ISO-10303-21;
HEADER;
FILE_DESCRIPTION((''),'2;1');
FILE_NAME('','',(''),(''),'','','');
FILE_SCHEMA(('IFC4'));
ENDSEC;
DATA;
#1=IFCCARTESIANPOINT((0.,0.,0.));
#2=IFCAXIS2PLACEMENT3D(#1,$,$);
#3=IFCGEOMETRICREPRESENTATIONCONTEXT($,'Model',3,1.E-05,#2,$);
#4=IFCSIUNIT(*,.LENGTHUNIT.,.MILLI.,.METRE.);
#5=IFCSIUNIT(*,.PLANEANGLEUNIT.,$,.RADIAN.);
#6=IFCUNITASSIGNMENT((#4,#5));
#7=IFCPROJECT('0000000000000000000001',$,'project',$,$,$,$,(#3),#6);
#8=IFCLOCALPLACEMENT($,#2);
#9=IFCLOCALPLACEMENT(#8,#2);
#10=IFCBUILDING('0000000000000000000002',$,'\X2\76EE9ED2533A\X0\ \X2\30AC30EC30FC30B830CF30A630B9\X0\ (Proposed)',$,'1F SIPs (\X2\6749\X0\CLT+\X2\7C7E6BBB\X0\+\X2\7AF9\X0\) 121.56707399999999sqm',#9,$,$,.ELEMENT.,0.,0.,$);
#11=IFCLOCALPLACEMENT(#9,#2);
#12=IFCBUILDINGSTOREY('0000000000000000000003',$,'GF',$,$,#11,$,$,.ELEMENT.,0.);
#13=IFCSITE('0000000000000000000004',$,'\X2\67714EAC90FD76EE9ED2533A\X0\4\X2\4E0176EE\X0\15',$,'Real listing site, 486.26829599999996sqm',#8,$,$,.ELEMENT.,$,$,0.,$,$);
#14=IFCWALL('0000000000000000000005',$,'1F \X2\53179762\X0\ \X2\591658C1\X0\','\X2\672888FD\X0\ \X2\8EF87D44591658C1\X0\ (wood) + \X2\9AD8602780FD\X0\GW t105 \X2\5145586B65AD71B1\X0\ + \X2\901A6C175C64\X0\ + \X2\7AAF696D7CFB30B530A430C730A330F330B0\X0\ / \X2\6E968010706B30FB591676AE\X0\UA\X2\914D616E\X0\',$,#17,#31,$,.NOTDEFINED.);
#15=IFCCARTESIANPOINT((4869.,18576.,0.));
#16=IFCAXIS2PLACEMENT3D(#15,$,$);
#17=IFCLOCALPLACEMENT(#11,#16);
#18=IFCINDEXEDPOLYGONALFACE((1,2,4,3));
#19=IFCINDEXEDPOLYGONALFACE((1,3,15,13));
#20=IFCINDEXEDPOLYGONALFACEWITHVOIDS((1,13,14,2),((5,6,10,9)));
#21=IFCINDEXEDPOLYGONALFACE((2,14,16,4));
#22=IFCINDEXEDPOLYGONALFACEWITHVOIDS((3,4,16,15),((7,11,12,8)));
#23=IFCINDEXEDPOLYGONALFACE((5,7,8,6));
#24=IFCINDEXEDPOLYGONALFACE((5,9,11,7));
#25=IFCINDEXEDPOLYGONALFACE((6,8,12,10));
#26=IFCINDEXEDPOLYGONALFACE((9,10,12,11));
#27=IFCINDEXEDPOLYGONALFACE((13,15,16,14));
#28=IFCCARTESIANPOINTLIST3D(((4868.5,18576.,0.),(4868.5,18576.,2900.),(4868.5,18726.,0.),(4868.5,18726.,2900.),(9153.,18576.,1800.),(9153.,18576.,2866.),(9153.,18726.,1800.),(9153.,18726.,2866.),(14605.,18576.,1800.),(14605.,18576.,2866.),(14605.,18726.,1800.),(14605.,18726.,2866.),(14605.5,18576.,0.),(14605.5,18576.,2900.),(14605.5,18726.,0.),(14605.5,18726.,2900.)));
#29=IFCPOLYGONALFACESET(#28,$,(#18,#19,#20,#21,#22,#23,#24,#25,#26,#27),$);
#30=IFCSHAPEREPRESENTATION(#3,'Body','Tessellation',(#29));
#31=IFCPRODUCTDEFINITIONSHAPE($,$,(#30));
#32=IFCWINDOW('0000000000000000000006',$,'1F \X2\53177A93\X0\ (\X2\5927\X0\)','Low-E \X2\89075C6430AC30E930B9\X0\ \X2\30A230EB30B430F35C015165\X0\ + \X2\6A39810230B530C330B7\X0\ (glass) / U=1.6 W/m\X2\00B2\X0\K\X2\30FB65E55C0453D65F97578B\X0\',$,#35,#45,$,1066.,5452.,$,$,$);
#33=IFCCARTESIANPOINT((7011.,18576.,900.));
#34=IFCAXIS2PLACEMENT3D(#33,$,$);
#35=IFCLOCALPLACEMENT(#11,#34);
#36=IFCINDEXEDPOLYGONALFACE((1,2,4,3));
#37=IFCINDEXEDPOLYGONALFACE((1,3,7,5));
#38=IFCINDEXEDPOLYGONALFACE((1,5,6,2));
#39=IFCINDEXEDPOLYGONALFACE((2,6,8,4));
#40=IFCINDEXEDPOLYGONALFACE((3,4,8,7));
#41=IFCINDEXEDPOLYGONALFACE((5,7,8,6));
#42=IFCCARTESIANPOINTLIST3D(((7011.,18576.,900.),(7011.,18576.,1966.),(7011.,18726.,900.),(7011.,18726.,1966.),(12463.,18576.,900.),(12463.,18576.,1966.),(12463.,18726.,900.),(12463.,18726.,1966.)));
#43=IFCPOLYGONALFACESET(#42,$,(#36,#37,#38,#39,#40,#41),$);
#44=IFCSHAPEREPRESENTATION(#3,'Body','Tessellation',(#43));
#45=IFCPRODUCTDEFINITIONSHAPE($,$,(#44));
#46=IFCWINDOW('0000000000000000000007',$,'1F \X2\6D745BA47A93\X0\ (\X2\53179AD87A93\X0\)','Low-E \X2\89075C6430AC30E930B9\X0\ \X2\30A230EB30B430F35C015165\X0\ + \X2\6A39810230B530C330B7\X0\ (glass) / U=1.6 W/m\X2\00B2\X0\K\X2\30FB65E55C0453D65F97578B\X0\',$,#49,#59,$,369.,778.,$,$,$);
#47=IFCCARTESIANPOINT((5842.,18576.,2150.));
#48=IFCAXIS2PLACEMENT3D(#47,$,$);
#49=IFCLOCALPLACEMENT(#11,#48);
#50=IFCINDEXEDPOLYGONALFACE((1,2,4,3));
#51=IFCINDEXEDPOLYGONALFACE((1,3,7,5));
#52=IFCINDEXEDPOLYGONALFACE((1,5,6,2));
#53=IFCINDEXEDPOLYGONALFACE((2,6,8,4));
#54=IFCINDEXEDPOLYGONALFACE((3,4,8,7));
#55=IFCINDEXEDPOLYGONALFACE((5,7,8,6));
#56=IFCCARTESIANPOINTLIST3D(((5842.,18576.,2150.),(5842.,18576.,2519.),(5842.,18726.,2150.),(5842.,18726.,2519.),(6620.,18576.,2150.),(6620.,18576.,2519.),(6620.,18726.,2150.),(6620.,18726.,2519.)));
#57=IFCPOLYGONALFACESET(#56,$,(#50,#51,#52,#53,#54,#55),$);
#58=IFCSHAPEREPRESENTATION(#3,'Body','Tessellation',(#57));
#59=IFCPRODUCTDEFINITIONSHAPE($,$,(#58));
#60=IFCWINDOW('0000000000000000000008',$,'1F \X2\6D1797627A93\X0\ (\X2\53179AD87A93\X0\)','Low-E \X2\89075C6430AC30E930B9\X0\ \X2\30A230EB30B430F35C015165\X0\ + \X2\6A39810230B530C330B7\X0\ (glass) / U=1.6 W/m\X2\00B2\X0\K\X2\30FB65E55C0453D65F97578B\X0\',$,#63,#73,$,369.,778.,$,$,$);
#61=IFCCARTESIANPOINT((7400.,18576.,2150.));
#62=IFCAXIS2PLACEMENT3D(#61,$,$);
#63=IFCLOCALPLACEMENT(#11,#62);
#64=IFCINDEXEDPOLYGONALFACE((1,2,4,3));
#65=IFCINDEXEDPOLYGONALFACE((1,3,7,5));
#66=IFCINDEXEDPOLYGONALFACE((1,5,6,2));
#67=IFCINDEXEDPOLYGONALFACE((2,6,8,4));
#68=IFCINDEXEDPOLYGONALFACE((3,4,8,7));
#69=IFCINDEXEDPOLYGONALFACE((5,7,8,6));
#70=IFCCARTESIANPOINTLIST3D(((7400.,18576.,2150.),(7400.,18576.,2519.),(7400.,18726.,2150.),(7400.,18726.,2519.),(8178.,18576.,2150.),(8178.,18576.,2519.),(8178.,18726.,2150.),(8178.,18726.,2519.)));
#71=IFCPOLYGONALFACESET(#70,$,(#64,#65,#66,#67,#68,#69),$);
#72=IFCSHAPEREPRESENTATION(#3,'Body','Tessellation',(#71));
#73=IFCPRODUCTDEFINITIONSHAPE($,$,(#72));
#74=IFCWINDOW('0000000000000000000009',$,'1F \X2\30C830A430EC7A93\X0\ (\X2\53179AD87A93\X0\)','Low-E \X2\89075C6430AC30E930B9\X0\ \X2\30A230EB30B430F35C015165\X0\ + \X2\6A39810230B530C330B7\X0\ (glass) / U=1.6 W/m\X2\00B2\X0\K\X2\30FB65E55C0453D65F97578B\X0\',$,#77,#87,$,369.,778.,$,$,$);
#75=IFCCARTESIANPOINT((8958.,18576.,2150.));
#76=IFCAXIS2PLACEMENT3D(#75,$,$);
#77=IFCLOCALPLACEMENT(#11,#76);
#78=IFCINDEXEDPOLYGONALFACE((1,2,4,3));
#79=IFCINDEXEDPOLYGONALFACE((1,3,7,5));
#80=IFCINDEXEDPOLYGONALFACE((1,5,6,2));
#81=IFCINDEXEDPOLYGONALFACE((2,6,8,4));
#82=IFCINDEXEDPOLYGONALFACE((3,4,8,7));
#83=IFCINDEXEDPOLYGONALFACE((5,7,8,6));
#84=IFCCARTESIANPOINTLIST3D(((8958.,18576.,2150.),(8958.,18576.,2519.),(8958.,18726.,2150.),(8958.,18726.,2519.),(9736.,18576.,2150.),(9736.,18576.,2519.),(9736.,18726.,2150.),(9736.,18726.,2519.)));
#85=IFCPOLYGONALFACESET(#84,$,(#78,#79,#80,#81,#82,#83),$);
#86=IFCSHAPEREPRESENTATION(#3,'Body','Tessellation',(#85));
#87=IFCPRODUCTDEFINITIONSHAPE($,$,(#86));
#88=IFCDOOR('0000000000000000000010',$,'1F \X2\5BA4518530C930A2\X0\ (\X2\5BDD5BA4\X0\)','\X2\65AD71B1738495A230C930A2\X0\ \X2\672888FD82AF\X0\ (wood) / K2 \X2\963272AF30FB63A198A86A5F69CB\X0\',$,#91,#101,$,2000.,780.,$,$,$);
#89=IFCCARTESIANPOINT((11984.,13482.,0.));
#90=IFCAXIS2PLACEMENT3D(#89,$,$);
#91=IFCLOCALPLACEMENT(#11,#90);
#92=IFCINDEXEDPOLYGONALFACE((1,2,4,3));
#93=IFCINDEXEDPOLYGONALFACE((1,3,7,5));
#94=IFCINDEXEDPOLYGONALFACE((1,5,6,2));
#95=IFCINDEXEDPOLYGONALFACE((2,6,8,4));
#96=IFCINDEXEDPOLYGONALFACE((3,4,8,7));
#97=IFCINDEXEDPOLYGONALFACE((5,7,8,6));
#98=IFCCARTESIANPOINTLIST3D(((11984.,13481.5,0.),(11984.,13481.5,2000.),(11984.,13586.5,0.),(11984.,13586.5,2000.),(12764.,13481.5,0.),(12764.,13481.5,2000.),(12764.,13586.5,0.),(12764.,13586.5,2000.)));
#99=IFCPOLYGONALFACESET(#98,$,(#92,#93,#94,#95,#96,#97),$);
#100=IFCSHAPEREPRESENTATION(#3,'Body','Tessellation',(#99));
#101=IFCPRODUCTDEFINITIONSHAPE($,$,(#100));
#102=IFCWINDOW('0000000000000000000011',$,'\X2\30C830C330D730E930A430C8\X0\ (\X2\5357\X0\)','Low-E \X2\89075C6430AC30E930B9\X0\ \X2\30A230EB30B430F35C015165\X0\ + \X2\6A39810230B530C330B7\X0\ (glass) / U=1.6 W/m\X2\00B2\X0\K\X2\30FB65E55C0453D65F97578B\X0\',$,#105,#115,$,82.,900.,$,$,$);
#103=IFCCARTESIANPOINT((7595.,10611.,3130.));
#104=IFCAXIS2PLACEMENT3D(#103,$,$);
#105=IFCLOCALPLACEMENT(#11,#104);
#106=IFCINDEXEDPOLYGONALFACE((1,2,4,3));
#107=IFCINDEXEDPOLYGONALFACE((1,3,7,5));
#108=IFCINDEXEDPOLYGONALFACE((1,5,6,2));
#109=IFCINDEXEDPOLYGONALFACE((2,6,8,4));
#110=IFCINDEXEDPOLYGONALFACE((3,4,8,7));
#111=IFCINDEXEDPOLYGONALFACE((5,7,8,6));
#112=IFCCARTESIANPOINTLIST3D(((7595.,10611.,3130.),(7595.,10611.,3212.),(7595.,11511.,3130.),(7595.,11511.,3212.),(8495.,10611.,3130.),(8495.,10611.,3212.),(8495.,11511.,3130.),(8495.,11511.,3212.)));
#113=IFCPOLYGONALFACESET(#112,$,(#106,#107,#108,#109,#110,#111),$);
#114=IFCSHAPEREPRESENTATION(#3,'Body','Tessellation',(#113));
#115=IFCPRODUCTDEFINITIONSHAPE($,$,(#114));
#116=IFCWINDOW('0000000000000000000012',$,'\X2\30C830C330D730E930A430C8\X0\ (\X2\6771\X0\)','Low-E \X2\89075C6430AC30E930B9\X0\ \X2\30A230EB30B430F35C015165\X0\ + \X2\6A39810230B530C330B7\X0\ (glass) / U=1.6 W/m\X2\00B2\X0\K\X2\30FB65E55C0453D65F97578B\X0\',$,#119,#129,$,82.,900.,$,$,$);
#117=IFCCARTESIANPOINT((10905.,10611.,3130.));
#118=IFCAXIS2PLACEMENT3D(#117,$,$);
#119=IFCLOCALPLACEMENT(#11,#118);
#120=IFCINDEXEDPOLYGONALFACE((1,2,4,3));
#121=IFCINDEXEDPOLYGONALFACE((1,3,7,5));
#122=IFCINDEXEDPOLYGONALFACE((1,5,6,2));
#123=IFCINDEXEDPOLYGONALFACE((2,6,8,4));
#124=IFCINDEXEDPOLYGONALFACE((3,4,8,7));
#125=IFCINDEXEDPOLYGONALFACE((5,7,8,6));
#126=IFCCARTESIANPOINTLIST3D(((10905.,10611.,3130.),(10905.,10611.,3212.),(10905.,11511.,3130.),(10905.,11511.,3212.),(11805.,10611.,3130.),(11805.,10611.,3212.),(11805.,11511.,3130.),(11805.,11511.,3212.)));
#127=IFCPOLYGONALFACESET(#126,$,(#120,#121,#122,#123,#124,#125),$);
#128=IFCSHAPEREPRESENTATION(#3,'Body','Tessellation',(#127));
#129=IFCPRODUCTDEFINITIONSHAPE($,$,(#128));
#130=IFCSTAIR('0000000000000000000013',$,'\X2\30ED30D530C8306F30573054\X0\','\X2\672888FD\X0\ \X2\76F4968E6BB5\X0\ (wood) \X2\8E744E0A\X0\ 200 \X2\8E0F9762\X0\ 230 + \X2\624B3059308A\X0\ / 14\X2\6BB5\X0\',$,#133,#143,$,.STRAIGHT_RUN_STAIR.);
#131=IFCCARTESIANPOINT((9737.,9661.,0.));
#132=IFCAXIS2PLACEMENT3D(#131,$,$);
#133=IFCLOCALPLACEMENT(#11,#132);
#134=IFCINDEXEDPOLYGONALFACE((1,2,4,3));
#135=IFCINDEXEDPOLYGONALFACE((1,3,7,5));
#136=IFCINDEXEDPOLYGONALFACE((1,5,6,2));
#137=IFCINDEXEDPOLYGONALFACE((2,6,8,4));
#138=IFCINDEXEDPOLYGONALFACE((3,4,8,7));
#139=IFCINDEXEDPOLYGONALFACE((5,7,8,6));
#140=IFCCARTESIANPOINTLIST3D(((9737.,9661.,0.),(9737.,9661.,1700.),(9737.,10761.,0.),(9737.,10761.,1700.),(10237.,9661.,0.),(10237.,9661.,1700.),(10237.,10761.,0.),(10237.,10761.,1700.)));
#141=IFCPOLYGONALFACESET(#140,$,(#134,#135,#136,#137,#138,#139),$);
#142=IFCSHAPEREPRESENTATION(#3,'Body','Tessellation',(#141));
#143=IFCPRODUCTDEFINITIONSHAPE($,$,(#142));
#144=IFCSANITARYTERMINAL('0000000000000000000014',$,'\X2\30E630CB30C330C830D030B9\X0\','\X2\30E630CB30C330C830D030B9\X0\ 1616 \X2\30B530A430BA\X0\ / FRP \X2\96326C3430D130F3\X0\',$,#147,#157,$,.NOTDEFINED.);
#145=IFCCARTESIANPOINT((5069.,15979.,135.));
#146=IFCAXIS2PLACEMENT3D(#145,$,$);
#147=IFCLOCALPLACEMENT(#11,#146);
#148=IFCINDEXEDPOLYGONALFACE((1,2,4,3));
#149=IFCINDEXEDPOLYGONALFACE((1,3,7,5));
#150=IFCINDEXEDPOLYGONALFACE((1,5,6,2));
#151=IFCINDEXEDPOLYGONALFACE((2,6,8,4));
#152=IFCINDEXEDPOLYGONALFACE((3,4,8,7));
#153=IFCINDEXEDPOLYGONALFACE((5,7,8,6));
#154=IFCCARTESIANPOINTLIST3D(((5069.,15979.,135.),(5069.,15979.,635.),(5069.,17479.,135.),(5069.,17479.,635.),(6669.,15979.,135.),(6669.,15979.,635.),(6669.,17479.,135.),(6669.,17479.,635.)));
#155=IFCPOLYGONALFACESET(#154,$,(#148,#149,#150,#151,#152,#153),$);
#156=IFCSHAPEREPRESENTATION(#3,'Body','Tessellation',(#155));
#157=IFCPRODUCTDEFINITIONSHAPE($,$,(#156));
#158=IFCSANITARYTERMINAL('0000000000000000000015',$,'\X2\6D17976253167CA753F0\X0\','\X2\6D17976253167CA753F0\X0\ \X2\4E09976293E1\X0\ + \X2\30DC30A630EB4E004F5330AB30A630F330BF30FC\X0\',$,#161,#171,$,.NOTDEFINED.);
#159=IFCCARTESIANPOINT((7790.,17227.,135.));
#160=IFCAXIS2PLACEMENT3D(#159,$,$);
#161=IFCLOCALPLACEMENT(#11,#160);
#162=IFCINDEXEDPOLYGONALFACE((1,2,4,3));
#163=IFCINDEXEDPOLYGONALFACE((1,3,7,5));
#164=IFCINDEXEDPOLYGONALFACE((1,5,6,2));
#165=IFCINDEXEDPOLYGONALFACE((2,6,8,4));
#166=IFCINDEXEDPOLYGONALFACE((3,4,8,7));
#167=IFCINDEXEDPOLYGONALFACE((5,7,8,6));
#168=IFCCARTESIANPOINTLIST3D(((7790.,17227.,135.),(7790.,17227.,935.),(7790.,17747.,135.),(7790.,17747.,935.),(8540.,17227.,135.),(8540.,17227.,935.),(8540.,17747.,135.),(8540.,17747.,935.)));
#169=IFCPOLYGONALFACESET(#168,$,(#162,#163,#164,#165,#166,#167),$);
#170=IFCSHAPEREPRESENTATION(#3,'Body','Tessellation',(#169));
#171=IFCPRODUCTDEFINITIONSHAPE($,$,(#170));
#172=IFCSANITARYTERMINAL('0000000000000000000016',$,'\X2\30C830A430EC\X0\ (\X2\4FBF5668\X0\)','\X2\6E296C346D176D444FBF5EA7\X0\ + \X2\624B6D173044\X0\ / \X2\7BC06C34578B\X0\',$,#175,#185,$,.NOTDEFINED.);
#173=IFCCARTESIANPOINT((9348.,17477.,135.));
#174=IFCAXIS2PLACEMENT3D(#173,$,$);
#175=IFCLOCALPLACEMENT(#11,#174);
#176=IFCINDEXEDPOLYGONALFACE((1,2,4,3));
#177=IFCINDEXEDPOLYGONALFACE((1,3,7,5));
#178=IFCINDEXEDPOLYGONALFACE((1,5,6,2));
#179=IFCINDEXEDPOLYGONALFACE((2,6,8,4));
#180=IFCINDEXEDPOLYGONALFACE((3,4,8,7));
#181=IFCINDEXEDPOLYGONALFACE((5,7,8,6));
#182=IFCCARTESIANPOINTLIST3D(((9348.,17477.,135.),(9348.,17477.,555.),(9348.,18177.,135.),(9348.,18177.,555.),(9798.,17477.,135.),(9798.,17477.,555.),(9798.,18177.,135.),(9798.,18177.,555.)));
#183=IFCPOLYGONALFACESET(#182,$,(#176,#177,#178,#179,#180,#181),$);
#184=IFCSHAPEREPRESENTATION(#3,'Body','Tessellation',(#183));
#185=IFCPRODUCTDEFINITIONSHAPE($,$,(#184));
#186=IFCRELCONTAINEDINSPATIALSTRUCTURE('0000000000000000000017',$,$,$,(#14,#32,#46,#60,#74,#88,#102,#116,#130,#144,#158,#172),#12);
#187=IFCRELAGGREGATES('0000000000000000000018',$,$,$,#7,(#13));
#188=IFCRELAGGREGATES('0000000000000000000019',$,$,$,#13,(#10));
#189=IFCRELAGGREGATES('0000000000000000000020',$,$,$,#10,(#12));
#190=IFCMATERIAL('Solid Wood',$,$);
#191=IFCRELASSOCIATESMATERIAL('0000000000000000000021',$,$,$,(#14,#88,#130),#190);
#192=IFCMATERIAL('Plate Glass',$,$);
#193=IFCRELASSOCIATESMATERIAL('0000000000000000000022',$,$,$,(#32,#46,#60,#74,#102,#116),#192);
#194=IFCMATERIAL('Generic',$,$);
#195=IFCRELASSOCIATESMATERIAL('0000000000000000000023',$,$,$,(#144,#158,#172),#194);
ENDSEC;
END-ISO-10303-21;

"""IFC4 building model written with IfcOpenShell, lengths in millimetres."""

from ifc_helpers import new_model, si_unit, frame, frame_2d, origin, place, context, project, spatial, rectangle, extrude, material, element, fill, save


model = new_model("IFC4")

# Units and contexts
model_context = context("Model", 3, precision=1e-05, world=origin())
ifc_project = project(units=[si_unit("LENGTHUNIT", "METRE", prefix="MILLI"), si_unit("PLANEANGLEUNIT", "RADIAN")], contexts=[model_context])

# Site, building, storey
site_placement = place(None, origin())
site = spatial("IfcSite", under=ifc_project, at=site_placement, Name="東京都目黒区4丁目15", ObjectType="Real listing site, 486.26829599999996sqm", CompositionType="ELEMENT", RefElevation=0.0)
building_placement = place(site_placement, origin())
building = spatial("IfcBuilding", under=site, at=building_placement, Name="目黒区 ガレージハウス (Proposed)", ObjectType="1F SIPs (杉CLT+籾殻+竹) 121.56707399999999sqm", CompositionType="ELEMENT", ElevationOfRefHeight=0.0, ElevationOfTerrain=0.0)
storey_placement = place(building_placement, origin())
storey = spatial("IfcBuildingStorey", under=building, at=storey_placement, Name="GF", CompositionType="ELEMENT", Elevation=0.0)

# Shared definitions
ifc_material_1 = material(Name="Solid Wood")

# Wall, openings, windows
wall_1_placement = place(storey_placement, frame((4869.0, 18576.0, 0.0)))
wall_1 = element("IfcWall", 1, at=wall_1_placement, inside=storey, material=ifc_material_1, Name="1F 北面 外壁", Description="木製 軸組外壁 (wood) + 高性能GW t105 充填断熱 + 通気層 + 窯業系サイディング / 準耐火・外皮UA配慮", PredefinedType="NOTDEFINED", context=model_context, shape_type="SweptSolid", body=[
    extrude(rectangle(XDim=9737.0, YDim=150.0, at=frame_2d((4868.0, 75.0))), frame((4869.0, 18576.0, 0.0)), (0.0, 0.0, 1.0), 2900.0),
])
opening_1_placement = place(storey_placement, frame((7011.0, 18576.0, 900.0)))
opening_1 = element("IfcOpeningElement", 2, at=opening_1_placement, cuts=wall_1, PredefinedType="NOTDEFINED", context=model_context, shape_type="SweptSolid", body=[
    extrude(rectangle(XDim=5452.0, YDim=150.0, at=frame_2d((2726.0, 75.0))), frame((7011.0, 18576.0, 900.0)), (0.0, 0.0, 1.0), 1066.0),
])
opening_2_placement = place(storey_placement, frame((5842.0, 18576.0, 2150.0)))
opening_2 = element("IfcOpeningElement", 3, at=opening_2_placement, cuts=wall_1, PredefinedType="NOTDEFINED", context=model_context, shape_type="SweptSolid", body=[
    extrude(rectangle(XDim=778.0, YDim=150.0, at=frame_2d((389.0, 75.0))), frame((5842.0, 18576.0, 2150.0)), (0.0, 0.0, 1.0), 369.0),
])
opening_3_placement = place(storey_placement, frame((7400.0, 18576.0, 2150.0)))
opening_3 = element("IfcOpeningElement", 4, at=opening_3_placement, cuts=wall_1, PredefinedType="NOTDEFINED", context=model_context, shape_type="SweptSolid", body=[
    extrude(rectangle(XDim=778.0, YDim=150.0, at=frame_2d((389.0, 75.0))), frame((7400.0, 18576.0, 2150.0)), (0.0, 0.0, 1.0), 369.0),
])
opening_4_placement = place(storey_placement, frame((8958.0, 18576.0, 2150.0)))
opening_4 = element("IfcOpeningElement", 5, at=opening_4_placement, cuts=wall_1, PredefinedType="NOTDEFINED", context=model_context, shape_type="SweptSolid", body=[
    extrude(rectangle(XDim=778.0, YDim=150.0, at=frame_2d((389.0, 75.0))), frame((8958.0, 18576.0, 2150.0)), (0.0, 0.0, 1.0), 369.0),
])
ifc_material_2 = material(Name="Plate Glass")
window_1_placement = place(storey_placement, frame((7011.0, 18576.0, 900.0)))
window_1 = element("IfcWindow", 6, at=window_1_placement, inside=storey, material=ifc_material_2, Name="1F 北窓 (大)", Description="Low-E 複層ガラス アルゴン封入 + 樹脂サッシ (glass) / U=1.6 W/m²K・日射取得型", OverallHeight=1066.0, OverallWidth=5452.0, context=model_context, shape_type="SweptSolid", body=[
    extrude(rectangle(XDim=5452.0, YDim=150.0, at=frame_2d((2726.0, 75.0))), frame((7011.0, 18576.0, 900.0)), (0.0, 0.0, 1.0), 1066.0),
])
fill(opening_1, window_1)
window_2_placement = place(storey_placement, frame((5842.0, 18576.0, 2150.0)))
window_2 = element("IfcWindow", 7, at=window_2_placement, inside=storey, material=ifc_material_2, Name="1F 浴室窓 (北高窓)", Description="Low-E 複層ガラス アルゴン封入 + 樹脂サッシ (glass) / U=1.6 W/m²K・日射取得型", OverallHeight=369.0, OverallWidth=778.0, context=model_context, shape_type="SweptSolid", body=[
    extrude(rectangle(XDim=778.0, YDim=150.0, at=frame_2d((389.0, 75.0))), frame((5842.0, 18576.0, 2150.0)), (0.0, 0.0, 1.0), 369.0),
])
fill(opening_2, window_2)
window_3_placement = place(storey_placement, frame((7400.0, 18576.0, 2150.0)))
window_3 = element("IfcWindow", 8, at=window_3_placement, inside=storey, material=ifc_material_2, Name="1F 洗面窓 (北高窓)", Description="Low-E 複層ガラス アルゴン封入 + 樹脂サッシ (glass) / U=1.6 W/m²K・日射取得型", OverallHeight=369.0, OverallWidth=778.0, context=model_context, shape_type="SweptSolid", body=[
    extrude(rectangle(XDim=778.0, YDim=150.0, at=frame_2d((389.0, 75.0))), frame((7400.0, 18576.0, 2150.0)), (0.0, 0.0, 1.0), 369.0),
])
fill(opening_3, window_3)
window_4_placement = place(storey_placement, frame((8958.0, 18576.0, 2150.0)))
window_4 = element("IfcWindow", 9, at=window_4_placement, inside=storey, material=ifc_material_2, Name="1F トイレ窓 (北高窓)", Description="Low-E 複層ガラス アルゴン封入 + 樹脂サッシ (glass) / U=1.6 W/m²K・日射取得型", OverallHeight=369.0, OverallWidth=778.0, context=model_context, shape_type="SweptSolid", body=[
    extrude(rectangle(XDim=778.0, YDim=150.0, at=frame_2d((389.0, 75.0))), frame((8958.0, 18576.0, 2150.0)), (0.0, 0.0, 1.0), 369.0),
])
fill(opening_4, window_4)

# Door
door_1_placement = place(storey_placement, frame((11984.0, 13482.0, 0.0)))
element("IfcDoor", 10, at=door_1_placement, inside=storey, material=ifc_material_1, Name="1F 室内ドア (寝室)", Description="断熱玄関ドア 木製芯 (wood) / K2 防犯・採風機構", OverallHeight=2000.0, OverallWidth=780.0, context=model_context, shape_type="SweptSolid", body=[
    extrude(rectangle(XDim=780.0, YDim=105.0, at=frame_2d((390.0, 52.0))), frame((11984.0, 13482.0, 0.0)), (0.0, 0.0, 1.0), 2000.0),
])

# Windows
window_5_placement = place(storey_placement, frame((7595.0, 10611.0, 3130.0)))
element("IfcWindow", 11, at=window_5_placement, inside=storey, material=ifc_material_2, Name="トップライト (南)", Description="Low-E 複層ガラス アルゴン封入 + 樹脂サッシ (glass) / U=1.6 W/m²K・日射取得型", OverallHeight=82.0, OverallWidth=900.0, context=model_context, shape_type="SweptSolid", body=[
    extrude(rectangle(XDim=900.0, YDim=900.0, at=frame_2d((450.0, 450.0))), frame((7595.0, 10611.0, 3130.0)), (0.0, 0.0, 1.0), 82.0),
])
window_6_placement = place(storey_placement, frame((10905.0, 10611.0, 3130.0)))
element("IfcWindow", 12, at=window_6_placement, inside=storey, material=ifc_material_2, Name="トップライト (東)", Description="Low-E 複層ガラス アルゴン封入 + 樹脂サッシ (glass) / U=1.6 W/m²K・日射取得型", OverallHeight=82.0, OverallWidth=900.0, context=model_context, shape_type="SweptSolid", body=[
    extrude(rectangle(XDim=900.0, YDim=900.0, at=frame_2d((450.0, 450.0))), frame((10905.0, 10611.0, 3130.0)), (0.0, 0.0, 1.0), 82.0),
])

# Stair
stair_placement = place(storey_placement, frame((9737.0, 9661.0, 0.0)))
element("IfcStair", 13, at=stair_placement, inside=storey, material=ifc_material_1, Name="ロフトはしご", Description="木製 直階段 (wood) 蹴上 200 踏面 230 + 手すり / 14段", PredefinedType="STRAIGHT_RUN_STAIR", context=model_context, shape_type="SweptSolid", body=[
    extrude(rectangle(XDim=500.0, YDim=1100.0, at=frame_2d((250.0, 550.0))), frame((9737.0, 9661.0, 0.0)), (0.0, 0.0, 1.0), 1700.0),
])

# Sanitary terminals
ifc_material_3 = material(Name="Generic")
sanitary_terminal_1_placement = place(storey_placement, frame((5069.0, 15979.0, 135.0)))
element("IfcSanitaryTerminal", 14, at=sanitary_terminal_1_placement, inside=storey, material=ifc_material_3, Name="ユニットバス", Description="ユニットバス 1616 サイズ / FRP 防水パン", PredefinedType="NOTDEFINED", context=model_context, shape_type="SweptSolid", body=[
    extrude(rectangle(XDim=1600.0, YDim=1500.0, at=frame_2d((800.0, 750.0))), frame((5069.0, 15979.0, 135.0)), (0.0, 0.0, 1.0), 500.0),
])
sanitary_terminal_2_placement = place(storey_placement, frame((7790.0, 17227.0, 135.0)))
element("IfcSanitaryTerminal", 15, at=sanitary_terminal_2_placement, inside=storey, material=ifc_material_3, Name="洗面化粧台", Description="洗面化粧台 三面鏡 + ボウル一体カウンター", PredefinedType="NOTDEFINED", context=model_context, shape_type="SweptSolid", body=[
    extrude(rectangle(XDim=750.0, YDim=520.0, at=frame_2d((375.0, 260.0))), frame((7790.0, 17227.0, 135.0)), (0.0, 0.0, 1.0), 800.0),
])
sanitary_terminal_3_placement = place(storey_placement, frame((9348.0, 17477.0, 135.0)))
element("IfcSanitaryTerminal", 16, at=sanitary_terminal_3_placement, inside=storey, material=ifc_material_3, Name="トイレ (便器)", Description="温水洗浄便座 + 手洗い / 節水型", PredefinedType="NOTDEFINED", context=model_context, shape_type="SweptSolid", body=[
    extrude(rectangle(XDim=450.0, YDim=700.0, at=frame_2d((225.0, 350.0))), frame((9348.0, 17477.0, 135.0)), (0.0, 0.0, 1.0), 420.0),
])

save(model, "model.ifc")
